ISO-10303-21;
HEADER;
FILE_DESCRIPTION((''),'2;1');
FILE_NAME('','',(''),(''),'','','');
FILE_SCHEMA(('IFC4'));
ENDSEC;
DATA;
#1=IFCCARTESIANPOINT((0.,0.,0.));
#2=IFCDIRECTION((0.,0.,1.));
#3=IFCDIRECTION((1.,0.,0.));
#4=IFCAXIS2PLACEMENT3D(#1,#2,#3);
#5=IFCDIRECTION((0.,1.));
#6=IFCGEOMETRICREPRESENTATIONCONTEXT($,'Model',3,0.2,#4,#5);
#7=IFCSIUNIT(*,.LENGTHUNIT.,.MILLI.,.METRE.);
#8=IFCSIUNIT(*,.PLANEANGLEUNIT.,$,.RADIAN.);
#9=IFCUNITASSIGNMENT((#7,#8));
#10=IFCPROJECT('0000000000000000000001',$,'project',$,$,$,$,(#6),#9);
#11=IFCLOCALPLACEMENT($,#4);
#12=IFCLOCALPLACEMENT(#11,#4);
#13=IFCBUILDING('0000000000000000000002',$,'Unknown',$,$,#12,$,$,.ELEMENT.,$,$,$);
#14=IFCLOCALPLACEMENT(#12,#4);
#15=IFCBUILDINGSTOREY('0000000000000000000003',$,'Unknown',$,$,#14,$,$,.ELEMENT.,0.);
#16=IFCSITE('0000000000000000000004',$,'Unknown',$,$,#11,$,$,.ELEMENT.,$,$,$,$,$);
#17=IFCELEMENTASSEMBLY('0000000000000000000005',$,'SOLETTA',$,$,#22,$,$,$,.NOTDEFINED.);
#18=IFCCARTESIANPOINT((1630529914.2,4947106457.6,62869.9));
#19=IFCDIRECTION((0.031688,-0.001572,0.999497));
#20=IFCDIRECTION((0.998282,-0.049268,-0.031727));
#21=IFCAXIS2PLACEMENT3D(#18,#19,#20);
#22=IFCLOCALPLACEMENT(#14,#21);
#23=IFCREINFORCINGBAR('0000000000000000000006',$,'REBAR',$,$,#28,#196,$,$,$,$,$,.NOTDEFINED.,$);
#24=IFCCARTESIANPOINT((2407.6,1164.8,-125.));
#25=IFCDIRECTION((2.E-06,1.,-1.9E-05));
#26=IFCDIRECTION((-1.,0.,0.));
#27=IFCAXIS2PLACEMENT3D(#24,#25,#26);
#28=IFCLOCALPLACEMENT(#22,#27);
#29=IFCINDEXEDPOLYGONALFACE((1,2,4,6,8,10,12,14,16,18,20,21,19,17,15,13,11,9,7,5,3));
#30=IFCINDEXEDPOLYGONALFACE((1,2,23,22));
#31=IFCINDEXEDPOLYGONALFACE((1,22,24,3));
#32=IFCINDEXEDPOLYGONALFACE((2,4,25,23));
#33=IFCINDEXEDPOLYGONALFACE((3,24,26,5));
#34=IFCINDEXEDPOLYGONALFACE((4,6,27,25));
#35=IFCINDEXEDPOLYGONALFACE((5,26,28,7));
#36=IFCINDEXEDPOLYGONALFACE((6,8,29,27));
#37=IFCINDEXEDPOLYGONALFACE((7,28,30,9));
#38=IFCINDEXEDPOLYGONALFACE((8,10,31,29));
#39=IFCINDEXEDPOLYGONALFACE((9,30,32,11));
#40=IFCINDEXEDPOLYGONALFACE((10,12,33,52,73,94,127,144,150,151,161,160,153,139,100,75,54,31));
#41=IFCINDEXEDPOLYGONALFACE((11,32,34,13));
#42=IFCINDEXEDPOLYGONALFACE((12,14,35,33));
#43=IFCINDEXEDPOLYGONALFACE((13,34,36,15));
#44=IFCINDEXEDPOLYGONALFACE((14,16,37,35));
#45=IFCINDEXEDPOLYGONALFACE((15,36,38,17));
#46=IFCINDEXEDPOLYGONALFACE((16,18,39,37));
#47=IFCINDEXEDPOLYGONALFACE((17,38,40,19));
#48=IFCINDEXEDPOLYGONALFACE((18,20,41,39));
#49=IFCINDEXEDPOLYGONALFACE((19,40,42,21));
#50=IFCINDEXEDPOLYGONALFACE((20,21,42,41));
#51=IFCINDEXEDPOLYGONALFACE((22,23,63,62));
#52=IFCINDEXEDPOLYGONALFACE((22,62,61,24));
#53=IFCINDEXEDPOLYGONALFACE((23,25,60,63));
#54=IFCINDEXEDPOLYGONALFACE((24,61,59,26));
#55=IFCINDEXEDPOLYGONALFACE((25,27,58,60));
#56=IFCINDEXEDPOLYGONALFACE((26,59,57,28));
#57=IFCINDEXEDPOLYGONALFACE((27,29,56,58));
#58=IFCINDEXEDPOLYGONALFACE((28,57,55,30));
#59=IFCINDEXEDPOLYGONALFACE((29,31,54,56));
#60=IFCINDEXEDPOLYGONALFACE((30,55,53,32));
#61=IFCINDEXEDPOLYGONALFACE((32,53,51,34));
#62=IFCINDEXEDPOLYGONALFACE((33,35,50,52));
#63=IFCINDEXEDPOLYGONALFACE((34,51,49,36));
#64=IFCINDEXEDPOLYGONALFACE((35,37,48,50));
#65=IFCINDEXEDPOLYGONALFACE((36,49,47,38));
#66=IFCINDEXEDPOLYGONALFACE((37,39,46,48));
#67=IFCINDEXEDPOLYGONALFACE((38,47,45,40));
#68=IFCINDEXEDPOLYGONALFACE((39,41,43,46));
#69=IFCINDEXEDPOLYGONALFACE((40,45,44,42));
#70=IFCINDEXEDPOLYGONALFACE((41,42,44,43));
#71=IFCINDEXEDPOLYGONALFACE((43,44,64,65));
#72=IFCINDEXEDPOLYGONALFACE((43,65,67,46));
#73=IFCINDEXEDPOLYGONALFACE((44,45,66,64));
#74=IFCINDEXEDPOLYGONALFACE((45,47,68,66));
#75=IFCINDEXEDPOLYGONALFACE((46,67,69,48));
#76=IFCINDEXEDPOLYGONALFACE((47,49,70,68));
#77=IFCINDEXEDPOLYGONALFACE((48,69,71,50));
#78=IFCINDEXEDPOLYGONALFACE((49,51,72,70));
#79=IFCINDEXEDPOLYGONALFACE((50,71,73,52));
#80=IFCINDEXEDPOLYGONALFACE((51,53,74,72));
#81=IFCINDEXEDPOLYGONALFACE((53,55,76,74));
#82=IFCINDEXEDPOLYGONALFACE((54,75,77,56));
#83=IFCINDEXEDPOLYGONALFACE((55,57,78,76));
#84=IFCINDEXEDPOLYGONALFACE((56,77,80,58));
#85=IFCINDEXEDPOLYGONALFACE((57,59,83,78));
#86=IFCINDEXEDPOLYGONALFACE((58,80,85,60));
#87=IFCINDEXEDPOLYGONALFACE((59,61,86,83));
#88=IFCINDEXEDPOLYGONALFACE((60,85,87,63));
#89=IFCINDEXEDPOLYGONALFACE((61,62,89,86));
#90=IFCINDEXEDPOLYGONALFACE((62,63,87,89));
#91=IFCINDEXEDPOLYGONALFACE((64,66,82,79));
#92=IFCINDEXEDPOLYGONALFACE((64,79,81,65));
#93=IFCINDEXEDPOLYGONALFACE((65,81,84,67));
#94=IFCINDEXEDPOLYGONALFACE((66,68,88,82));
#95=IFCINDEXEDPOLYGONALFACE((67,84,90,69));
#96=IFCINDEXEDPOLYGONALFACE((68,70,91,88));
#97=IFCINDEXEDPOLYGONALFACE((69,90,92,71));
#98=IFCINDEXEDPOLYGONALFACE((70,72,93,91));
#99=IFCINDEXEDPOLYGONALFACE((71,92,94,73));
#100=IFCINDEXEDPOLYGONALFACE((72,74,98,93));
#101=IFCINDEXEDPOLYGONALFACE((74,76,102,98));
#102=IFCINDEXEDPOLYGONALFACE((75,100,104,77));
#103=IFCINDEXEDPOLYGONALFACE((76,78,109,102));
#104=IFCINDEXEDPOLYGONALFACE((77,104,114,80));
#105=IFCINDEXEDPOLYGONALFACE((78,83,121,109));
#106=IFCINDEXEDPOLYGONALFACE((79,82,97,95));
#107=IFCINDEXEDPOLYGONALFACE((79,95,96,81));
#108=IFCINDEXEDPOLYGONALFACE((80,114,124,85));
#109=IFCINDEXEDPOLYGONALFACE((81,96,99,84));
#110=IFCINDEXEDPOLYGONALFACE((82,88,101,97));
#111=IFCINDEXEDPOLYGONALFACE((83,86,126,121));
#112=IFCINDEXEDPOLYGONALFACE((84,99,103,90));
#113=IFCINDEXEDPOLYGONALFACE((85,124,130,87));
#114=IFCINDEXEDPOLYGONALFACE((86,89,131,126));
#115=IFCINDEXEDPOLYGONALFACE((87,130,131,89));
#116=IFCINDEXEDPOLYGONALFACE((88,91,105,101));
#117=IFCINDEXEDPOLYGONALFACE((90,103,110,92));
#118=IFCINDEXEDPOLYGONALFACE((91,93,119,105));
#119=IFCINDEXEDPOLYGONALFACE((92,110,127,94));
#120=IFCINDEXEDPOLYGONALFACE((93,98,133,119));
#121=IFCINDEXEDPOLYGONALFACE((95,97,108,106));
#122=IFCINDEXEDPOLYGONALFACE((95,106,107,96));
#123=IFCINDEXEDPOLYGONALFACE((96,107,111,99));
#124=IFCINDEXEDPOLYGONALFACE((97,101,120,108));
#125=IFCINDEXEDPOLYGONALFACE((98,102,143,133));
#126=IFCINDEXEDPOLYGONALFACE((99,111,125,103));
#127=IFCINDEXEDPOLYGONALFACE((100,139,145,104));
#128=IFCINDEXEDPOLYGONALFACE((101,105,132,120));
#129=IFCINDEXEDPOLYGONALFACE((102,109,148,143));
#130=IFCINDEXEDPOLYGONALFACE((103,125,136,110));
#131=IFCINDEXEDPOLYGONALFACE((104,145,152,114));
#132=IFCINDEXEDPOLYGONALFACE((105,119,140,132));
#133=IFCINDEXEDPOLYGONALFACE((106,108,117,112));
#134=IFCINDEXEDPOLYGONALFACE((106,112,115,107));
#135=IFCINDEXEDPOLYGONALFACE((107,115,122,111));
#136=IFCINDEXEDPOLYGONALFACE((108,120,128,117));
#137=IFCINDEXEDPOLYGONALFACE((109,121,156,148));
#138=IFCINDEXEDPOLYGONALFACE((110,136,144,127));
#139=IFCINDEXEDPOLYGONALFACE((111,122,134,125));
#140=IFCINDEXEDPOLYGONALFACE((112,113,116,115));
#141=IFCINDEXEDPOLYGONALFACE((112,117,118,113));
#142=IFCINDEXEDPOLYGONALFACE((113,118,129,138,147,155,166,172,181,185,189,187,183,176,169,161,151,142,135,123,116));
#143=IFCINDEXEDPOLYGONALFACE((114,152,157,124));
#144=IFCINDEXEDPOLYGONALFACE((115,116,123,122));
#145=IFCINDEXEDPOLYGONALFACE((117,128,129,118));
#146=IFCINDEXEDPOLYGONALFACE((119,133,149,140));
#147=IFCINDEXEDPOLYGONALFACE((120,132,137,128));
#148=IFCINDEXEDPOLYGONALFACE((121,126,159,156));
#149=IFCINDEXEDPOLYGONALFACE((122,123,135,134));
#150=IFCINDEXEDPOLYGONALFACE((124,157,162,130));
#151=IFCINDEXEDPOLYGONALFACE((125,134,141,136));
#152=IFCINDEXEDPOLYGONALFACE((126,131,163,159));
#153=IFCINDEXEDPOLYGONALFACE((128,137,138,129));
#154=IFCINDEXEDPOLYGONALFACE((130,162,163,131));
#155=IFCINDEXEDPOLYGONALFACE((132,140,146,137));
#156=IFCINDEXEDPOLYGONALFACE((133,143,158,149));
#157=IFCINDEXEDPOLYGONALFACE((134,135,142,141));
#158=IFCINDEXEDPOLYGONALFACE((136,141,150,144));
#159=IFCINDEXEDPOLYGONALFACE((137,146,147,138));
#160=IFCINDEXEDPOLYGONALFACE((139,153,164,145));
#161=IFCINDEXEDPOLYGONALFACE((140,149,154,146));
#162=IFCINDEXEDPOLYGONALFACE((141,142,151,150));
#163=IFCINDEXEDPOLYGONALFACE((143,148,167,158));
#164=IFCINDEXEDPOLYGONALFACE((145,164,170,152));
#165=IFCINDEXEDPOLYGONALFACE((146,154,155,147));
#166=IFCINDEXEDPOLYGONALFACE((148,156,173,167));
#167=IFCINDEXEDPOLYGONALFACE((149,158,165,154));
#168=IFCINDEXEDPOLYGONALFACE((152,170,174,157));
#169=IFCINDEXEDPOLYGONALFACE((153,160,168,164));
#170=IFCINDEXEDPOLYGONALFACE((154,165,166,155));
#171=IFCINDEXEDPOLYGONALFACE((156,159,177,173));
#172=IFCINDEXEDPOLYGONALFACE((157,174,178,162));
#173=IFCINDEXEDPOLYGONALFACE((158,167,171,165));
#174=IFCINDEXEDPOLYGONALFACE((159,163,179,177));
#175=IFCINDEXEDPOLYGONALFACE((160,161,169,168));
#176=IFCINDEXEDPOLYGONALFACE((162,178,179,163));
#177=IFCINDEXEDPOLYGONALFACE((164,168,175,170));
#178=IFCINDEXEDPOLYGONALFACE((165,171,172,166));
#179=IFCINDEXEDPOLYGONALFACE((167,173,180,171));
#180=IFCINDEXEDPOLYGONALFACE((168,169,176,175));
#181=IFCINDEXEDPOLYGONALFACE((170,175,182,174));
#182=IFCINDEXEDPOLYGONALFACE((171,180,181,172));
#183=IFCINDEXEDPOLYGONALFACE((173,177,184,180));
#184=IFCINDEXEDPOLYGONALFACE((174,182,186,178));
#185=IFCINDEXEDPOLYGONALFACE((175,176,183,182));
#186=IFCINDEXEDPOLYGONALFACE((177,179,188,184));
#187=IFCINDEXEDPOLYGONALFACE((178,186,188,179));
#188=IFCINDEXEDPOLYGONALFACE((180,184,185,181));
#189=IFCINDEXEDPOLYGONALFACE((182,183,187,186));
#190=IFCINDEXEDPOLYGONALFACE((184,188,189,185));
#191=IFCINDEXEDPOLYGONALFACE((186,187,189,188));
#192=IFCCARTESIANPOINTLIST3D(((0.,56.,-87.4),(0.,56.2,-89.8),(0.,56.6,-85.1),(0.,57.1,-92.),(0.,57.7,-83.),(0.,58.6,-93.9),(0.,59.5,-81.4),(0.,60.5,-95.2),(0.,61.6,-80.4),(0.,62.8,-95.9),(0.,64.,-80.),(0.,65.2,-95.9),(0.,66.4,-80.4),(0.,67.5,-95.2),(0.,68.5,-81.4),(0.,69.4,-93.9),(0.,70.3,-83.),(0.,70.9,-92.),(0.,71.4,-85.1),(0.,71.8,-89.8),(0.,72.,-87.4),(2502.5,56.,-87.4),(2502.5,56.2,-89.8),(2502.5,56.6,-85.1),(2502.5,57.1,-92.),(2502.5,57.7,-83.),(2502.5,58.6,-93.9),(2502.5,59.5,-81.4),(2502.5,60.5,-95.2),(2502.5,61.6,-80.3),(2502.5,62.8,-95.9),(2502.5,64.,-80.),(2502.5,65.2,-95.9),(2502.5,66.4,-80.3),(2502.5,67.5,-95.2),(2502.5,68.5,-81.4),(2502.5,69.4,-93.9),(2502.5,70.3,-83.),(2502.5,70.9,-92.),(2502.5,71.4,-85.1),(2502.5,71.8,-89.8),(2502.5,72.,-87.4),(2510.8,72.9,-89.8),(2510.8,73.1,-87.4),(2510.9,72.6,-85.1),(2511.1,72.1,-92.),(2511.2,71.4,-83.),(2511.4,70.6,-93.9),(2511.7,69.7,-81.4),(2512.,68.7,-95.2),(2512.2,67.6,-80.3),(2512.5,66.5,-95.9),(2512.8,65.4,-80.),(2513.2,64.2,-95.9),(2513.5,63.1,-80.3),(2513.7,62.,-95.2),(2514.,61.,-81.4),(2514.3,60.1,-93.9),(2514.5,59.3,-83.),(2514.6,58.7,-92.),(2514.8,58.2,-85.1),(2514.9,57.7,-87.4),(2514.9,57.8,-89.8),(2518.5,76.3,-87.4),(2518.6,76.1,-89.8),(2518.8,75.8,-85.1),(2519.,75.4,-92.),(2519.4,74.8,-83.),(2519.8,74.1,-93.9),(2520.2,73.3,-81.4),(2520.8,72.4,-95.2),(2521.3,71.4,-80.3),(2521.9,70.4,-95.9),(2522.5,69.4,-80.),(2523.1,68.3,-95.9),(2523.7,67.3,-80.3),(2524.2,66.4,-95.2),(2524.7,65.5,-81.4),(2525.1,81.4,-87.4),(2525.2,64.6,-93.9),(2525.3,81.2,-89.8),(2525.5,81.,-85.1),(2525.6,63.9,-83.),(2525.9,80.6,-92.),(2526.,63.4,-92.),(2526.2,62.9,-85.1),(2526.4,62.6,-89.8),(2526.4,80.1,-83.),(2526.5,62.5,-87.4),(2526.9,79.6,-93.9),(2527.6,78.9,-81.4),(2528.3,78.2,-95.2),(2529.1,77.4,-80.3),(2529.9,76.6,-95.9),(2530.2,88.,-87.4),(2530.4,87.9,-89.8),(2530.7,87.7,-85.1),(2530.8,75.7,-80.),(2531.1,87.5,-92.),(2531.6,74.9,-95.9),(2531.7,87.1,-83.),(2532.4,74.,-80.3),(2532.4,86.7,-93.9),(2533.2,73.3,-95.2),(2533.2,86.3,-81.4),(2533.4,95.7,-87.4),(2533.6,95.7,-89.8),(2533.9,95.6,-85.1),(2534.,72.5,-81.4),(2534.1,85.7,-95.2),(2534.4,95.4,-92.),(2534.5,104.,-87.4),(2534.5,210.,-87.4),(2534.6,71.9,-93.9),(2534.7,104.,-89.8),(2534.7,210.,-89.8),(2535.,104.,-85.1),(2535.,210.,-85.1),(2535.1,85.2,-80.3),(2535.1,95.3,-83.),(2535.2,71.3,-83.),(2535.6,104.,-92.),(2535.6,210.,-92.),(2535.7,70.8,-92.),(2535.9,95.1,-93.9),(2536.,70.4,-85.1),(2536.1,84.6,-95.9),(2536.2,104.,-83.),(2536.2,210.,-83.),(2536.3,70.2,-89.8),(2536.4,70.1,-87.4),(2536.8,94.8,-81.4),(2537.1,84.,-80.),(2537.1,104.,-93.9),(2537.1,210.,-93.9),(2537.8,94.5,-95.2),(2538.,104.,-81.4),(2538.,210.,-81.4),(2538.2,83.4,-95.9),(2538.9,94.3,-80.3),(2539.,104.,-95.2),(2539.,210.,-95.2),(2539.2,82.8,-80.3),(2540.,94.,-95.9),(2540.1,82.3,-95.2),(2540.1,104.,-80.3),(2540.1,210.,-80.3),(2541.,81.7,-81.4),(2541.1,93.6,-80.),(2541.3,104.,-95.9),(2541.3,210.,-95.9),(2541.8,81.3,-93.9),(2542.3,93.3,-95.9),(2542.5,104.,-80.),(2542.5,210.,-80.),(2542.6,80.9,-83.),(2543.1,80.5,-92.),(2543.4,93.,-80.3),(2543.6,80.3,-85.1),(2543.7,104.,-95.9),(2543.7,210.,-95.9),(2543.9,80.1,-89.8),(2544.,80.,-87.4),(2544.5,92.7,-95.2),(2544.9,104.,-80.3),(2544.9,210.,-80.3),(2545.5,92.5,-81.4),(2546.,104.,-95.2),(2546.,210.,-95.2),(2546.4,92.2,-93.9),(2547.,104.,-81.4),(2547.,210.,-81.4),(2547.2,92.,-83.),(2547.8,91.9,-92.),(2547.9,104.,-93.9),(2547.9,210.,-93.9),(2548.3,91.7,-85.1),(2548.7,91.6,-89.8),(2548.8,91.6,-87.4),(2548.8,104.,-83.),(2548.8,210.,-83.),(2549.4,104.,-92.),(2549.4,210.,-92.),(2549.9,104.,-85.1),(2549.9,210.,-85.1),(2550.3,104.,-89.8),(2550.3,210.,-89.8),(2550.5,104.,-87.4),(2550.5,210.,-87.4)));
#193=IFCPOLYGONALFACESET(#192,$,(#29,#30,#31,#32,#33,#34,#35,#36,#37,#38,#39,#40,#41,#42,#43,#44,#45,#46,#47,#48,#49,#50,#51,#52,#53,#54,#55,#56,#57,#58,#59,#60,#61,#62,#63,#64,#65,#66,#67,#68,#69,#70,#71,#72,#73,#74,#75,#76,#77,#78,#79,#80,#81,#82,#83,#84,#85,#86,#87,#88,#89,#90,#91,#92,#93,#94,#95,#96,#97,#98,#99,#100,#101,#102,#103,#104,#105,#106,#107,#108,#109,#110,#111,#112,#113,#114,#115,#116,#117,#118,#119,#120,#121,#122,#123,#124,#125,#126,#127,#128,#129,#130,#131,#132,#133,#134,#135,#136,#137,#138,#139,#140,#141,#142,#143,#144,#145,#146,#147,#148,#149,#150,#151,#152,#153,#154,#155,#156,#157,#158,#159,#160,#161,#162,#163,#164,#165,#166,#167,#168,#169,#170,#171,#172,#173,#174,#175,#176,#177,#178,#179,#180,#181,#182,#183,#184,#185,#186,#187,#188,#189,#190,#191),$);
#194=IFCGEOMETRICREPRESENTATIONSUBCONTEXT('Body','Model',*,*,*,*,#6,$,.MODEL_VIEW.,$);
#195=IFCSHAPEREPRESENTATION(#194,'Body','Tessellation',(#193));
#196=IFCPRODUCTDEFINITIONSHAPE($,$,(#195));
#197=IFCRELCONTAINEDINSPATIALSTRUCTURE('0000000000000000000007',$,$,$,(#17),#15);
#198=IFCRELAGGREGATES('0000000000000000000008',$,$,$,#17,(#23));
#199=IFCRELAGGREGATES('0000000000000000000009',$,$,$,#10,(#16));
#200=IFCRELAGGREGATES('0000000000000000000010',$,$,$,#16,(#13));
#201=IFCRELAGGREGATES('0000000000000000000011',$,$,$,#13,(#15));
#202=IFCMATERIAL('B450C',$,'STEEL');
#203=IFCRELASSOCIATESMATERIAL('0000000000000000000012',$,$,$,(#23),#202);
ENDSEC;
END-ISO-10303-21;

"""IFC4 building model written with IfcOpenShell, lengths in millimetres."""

from ifc_helpers import new_model, entity, si_unit, direction, frame, origin_with_axes, place, context, subcontext, project, spatial, material, element, aggregate, save


model = new_model("IFC4")

# Units and contexts
model_context = context("Model", 3, precision=0.2, world=origin_with_axes(), true_north=direction((0.0, 1.0)))
body_context = subcontext(model_context, "Body", "Model", "MODEL_VIEW")
ifc_project = project(units=[si_unit("LENGTHUNIT", "METRE", prefix="MILLI"), si_unit("PLANEANGLEUNIT", "RADIAN")], contexts=[model_context])

# Site, building, storey
site_placement = place(None, origin_with_axes())
site = spatial("IfcSite", under=ifc_project, at=site_placement, Name="Unknown", CompositionType="ELEMENT")
building_placement = place(site_placement, origin_with_axes())
building = spatial("IfcBuilding", under=site, at=building_placement, Name="Unknown", CompositionType="ELEMENT")
storey_placement = place(building_placement, origin_with_axes())
storey = spatial("IfcBuildingStorey", under=building, at=storey_placement, Name="Unknown", CompositionType="ELEMENT", Elevation=0.0)

# Element assembly
ifc_material = material(Name="B450C", Category="STEEL")
assembly_1_placement = place(storey_placement, frame((1630529914.2, 4947106457.6, 62869.9), z_axis=(0.031688, -0.001572, 0.999497), x_axis=(0.998282, -0.049268, -0.031727)))
assembly_1 = element("IfcElementAssembly", 1, at=assembly_1_placement, inside=storey, Name="SOLETTA", PredefinedType="NOTDEFINED")

# Reinforcing bar
reinforcing_bar_1_placement = place(assembly_1_placement, frame((2407.6, 1164.8, -125.0), z_axis=(0.000002, 1.0, -0.000019), x_axis=(-1.0, 0.0, 0.0)))
reinforcing_bar_1 = element("IfcReinforcingBar", 2, at=reinforcing_bar_1_placement, material=ifc_material, Name="REBAR", PredefinedType="NOTDEFINED", context=body_context, shape_type="AdvancedSweptSolid", body=[
    entity("IfcSweptDiskSolid", entity("IfcIndexedPolyCurve", entity("IfcCartesianPointList3D", [[0.0, 64.0, -88.0], [2502.5, 64.0, -88.0], [2530.8, 75.7, -88.0], [2542.5, 104.0, -88.0], [2542.5, 210.0, -88.0]]), [entity("IfcLineIndex", [1, 2]), entity("IfcArcIndex", [2, 3, 4]), entity("IfcLineIndex", [4, 5])]), 8.0),
])
aggregate(assembly_1, [reinforcing_bar_1])

save(model, "model.ifc")
